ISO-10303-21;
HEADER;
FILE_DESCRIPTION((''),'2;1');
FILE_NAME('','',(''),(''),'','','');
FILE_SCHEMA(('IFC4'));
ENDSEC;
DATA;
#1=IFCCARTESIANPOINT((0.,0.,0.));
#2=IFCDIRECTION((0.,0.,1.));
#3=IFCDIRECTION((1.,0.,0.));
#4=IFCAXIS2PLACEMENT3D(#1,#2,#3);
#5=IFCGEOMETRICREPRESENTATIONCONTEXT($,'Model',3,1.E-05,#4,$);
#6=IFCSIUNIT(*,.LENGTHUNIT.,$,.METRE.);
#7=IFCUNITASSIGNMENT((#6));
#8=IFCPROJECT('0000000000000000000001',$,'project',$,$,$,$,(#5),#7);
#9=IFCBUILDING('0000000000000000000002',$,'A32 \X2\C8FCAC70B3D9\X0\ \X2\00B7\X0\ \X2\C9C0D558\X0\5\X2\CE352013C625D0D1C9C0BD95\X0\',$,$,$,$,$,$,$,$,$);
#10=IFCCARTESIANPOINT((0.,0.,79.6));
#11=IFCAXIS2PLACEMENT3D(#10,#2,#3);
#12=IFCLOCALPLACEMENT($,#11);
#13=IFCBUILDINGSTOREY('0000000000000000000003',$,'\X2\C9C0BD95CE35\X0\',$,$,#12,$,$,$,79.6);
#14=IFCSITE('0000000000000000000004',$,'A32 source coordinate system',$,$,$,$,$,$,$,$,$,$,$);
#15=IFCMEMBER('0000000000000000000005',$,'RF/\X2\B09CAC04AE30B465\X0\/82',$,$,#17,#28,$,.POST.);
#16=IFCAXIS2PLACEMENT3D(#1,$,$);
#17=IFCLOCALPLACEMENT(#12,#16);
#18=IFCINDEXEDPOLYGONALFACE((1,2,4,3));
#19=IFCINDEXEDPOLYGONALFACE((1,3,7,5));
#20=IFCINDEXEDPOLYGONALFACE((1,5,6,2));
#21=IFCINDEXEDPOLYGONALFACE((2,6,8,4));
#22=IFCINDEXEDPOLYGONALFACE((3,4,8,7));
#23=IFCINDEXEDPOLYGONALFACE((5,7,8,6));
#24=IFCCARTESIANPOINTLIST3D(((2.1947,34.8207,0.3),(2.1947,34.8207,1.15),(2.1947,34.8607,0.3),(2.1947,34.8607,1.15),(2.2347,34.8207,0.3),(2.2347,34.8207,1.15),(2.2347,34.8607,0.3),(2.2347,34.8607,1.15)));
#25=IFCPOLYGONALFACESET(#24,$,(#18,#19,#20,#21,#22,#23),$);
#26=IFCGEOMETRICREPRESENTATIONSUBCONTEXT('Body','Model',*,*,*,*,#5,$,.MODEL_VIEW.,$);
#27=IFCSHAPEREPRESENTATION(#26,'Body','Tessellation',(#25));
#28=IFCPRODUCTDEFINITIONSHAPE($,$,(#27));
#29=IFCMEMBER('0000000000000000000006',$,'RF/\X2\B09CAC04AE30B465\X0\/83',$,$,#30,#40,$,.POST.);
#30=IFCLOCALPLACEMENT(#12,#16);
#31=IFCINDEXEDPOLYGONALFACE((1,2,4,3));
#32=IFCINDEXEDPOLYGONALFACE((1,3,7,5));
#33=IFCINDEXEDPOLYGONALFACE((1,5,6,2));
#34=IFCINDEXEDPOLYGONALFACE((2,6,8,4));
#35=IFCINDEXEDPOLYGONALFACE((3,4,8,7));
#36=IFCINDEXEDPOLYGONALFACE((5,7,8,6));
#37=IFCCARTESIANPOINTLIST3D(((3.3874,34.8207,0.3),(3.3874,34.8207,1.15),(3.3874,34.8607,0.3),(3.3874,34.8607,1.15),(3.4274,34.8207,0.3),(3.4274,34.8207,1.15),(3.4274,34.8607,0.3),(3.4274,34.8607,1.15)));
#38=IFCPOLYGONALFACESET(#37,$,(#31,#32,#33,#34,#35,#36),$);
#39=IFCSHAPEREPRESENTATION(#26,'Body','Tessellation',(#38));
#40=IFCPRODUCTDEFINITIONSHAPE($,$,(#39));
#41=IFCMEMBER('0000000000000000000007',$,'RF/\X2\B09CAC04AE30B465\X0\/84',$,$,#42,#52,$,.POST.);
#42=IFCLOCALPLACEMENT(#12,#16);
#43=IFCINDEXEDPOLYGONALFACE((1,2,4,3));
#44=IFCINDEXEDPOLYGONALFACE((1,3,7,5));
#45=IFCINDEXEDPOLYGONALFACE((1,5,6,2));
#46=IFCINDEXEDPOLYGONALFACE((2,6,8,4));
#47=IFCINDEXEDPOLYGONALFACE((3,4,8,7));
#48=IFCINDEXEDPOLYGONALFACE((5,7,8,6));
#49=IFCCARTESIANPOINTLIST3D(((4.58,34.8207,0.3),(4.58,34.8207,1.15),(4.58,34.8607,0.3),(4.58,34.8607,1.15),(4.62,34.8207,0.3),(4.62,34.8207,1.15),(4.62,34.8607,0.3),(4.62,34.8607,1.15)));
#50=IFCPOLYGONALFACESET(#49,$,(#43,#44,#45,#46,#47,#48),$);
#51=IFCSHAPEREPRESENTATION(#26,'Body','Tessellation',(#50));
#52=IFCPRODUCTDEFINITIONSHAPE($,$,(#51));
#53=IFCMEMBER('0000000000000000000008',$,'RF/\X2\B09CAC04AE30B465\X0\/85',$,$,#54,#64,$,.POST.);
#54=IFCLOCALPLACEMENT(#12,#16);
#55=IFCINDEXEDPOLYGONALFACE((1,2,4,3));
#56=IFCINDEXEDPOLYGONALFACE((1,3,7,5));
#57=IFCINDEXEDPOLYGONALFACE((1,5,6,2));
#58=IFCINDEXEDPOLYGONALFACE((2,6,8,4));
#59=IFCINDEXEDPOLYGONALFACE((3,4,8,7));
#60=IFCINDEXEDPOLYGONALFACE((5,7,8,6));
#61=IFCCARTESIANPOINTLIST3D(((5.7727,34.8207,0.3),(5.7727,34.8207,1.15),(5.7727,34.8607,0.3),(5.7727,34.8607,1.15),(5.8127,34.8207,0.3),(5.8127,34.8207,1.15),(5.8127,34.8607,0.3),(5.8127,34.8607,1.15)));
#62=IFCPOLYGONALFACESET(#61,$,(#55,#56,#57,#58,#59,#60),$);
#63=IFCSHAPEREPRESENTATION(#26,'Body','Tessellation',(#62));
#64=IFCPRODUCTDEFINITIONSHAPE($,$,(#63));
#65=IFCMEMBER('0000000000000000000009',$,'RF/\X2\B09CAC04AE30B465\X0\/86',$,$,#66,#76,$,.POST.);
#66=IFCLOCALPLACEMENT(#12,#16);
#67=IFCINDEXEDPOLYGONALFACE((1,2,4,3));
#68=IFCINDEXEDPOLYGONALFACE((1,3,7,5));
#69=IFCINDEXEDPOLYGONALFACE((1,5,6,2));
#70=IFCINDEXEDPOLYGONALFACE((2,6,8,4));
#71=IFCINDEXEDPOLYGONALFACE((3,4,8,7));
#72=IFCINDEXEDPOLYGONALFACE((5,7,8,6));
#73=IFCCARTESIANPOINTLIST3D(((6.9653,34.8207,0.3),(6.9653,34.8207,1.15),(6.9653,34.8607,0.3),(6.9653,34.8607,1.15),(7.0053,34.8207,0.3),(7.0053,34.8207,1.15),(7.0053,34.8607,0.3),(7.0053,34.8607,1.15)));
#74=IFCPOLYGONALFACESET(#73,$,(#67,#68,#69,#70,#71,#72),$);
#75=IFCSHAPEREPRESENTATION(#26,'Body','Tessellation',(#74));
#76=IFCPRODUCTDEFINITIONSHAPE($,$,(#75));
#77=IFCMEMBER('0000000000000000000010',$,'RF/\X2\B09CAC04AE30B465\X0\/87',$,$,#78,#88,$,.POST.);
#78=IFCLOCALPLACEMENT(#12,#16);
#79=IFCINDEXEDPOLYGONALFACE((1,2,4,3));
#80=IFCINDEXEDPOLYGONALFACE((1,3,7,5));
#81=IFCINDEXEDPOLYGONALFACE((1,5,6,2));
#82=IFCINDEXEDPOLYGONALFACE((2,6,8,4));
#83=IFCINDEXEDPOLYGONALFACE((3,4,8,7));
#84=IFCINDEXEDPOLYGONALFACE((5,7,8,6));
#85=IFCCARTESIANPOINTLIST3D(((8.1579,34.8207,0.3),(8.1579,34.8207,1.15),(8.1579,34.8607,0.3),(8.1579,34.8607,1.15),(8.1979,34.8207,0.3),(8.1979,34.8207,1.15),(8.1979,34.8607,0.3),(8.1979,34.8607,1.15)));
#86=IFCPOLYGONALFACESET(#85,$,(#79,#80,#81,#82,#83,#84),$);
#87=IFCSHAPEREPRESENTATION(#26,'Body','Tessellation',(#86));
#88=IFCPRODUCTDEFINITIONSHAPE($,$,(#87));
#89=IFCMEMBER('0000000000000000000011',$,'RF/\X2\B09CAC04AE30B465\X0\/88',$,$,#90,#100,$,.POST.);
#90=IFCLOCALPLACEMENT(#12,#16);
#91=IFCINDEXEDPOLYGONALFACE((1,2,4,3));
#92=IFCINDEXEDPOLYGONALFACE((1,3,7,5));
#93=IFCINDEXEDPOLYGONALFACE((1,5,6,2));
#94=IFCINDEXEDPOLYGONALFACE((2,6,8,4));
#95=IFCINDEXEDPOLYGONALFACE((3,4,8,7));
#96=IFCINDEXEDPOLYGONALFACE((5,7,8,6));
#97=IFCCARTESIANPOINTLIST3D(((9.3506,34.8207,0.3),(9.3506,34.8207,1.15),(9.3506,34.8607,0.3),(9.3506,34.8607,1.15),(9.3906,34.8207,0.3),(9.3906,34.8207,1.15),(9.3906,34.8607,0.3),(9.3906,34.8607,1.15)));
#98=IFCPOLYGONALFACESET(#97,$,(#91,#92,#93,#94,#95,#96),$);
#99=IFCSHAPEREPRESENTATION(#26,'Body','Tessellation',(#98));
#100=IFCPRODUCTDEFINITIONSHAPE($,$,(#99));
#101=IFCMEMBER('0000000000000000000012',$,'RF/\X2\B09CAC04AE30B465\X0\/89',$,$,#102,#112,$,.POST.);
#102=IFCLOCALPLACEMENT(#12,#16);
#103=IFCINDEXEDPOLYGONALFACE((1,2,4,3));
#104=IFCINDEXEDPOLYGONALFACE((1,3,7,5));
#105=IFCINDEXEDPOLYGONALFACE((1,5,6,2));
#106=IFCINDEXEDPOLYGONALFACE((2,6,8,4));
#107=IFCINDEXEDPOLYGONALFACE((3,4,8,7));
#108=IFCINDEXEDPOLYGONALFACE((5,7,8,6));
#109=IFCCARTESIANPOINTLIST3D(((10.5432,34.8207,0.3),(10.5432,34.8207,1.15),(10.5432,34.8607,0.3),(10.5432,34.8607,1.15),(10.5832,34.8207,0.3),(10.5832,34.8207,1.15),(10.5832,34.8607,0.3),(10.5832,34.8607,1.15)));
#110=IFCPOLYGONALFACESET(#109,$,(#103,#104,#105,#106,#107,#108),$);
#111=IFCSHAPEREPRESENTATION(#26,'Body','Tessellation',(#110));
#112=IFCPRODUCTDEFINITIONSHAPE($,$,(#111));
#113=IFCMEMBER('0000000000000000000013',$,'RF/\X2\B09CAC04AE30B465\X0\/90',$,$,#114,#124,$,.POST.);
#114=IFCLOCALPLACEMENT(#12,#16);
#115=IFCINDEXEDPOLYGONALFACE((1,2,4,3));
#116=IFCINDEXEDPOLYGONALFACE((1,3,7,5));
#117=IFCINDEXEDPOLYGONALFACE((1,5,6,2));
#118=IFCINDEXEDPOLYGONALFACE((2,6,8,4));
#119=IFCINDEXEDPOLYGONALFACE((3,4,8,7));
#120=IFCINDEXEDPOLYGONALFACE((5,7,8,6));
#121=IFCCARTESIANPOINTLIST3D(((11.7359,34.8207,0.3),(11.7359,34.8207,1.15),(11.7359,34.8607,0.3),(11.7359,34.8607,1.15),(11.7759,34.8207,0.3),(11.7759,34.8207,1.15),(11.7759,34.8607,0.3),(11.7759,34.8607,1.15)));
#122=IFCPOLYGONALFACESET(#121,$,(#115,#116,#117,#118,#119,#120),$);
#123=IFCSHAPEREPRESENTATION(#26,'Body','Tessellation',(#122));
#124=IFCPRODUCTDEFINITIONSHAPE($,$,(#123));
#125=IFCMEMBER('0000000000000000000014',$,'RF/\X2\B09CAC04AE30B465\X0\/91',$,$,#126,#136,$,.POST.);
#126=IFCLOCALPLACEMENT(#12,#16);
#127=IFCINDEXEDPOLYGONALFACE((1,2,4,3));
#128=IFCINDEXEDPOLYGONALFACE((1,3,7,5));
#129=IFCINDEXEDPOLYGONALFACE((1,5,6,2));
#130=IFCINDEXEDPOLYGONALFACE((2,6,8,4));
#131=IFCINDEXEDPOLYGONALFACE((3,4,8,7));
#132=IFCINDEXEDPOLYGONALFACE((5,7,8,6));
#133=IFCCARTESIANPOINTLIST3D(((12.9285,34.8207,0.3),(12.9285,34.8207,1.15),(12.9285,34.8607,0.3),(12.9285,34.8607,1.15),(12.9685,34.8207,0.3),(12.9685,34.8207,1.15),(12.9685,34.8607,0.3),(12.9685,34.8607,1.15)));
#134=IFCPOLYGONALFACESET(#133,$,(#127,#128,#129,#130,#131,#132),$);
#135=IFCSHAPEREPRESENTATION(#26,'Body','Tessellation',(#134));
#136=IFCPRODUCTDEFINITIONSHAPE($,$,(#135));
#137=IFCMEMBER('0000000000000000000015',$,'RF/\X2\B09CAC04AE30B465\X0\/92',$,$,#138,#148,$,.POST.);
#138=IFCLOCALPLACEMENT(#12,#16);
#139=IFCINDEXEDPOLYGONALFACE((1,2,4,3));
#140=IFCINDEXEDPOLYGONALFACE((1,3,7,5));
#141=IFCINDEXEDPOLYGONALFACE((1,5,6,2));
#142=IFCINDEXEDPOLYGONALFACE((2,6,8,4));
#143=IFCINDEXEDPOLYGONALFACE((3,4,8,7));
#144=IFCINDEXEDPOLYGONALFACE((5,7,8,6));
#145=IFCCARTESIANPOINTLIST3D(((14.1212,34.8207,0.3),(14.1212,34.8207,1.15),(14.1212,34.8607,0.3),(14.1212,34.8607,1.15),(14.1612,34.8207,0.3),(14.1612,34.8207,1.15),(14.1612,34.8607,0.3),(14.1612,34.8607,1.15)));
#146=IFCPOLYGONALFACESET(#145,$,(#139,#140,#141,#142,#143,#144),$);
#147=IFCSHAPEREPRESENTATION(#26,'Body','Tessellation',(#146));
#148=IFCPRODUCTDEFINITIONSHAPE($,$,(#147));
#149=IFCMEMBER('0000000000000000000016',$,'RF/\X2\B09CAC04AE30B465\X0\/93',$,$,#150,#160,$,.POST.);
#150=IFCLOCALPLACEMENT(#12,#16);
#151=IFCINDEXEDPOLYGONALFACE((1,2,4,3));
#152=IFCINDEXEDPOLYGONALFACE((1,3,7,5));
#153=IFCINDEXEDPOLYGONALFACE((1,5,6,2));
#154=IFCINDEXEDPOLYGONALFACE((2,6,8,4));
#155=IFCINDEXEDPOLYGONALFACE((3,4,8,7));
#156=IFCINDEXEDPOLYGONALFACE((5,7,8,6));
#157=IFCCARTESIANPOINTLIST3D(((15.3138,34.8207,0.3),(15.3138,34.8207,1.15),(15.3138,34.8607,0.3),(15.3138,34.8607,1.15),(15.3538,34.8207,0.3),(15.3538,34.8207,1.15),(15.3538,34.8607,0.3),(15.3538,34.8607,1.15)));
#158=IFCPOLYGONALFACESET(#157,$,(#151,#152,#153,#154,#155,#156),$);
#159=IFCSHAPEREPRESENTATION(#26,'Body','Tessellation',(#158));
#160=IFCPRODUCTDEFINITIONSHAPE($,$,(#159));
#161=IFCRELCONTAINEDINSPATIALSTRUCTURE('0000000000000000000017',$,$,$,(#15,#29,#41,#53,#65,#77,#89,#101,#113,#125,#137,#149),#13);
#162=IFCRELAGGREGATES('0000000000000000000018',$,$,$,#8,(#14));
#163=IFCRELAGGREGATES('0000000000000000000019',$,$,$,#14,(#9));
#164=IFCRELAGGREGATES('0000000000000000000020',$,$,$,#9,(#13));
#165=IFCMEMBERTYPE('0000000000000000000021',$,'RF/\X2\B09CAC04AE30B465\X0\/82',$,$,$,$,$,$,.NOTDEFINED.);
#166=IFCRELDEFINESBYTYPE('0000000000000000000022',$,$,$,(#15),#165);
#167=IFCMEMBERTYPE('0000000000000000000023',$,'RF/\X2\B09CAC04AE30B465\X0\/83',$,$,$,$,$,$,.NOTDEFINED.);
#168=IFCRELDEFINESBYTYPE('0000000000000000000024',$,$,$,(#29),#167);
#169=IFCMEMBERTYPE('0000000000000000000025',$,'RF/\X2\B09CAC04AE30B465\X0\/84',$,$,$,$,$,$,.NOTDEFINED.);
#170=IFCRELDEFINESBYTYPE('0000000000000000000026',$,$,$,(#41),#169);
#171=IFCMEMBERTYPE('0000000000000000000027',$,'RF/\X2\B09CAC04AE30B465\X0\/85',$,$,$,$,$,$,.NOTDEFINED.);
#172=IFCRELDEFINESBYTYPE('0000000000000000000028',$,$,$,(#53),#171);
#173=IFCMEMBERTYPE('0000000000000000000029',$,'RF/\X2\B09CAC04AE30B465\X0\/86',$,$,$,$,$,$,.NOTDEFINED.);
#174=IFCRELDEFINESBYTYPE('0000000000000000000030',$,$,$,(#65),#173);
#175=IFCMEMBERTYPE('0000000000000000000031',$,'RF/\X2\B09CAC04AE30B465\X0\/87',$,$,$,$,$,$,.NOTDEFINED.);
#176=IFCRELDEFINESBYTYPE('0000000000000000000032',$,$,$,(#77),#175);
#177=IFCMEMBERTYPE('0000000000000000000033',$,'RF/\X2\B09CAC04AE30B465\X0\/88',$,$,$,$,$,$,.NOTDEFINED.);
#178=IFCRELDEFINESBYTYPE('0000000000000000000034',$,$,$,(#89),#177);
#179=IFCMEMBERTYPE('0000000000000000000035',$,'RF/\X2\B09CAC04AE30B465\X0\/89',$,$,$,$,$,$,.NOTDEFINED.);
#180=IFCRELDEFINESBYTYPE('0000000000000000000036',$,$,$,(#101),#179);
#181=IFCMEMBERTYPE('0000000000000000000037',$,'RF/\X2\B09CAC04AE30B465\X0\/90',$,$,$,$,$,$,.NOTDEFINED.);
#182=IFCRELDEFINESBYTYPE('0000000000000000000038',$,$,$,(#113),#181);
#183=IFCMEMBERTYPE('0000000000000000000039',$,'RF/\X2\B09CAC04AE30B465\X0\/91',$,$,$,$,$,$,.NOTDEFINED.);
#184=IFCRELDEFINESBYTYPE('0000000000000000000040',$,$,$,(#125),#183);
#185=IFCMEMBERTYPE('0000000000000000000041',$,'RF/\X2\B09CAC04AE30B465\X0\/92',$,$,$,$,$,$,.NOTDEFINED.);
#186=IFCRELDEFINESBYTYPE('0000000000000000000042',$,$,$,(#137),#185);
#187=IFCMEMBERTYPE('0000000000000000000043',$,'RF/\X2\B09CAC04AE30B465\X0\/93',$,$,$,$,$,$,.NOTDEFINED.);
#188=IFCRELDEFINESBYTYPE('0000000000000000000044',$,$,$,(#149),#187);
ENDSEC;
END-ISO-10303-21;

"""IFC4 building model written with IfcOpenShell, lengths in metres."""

from ifc_helpers import new_model, si_unit, frame, origin, origin_with_axes, place, context, subcontext, project, spatial, polyline, outline, extrude, source, transform, mapped, type_object, type_shapes, element, save


model = new_model("IFC4")

# Units and contexts
model_context = context("Model", 3, precision=1e-05, world=origin_with_axes())
body_context = subcontext(model_context, "Body", "Model", "MODEL_VIEW")
ifc_project = project(units=[si_unit("LENGTHUNIT", "METRE")], contexts=[model_context])

# Site, building, storey
site = spatial("IfcSite", under=ifc_project, Name="A32 source coordinate system")
building = spatial("IfcBuilding", under=site, Name="A32 주거동 · 지하5층–옥탑지붕")
storey_placement = place(None, frame((0.0, 0.0, 79.6), z_axis=(0.0, 0.0, 1.0), x_axis=(1.0, 0.0, 0.0)))
storey = spatial("IfcBuildingStorey", under=building, at=storey_placement, Name="지붕층", Elevation=79.6)

# Members
member_type_1 = type_object("IfcMemberType", Name="RF/난간기둥/82", PredefinedType="NOTDEFINED")
shared_shape_1 = source(origin(), body_context, "Body", "SweptSolid", [
    extrude(outline(polyline([(2.2347, 34.8207), (2.1947, 34.8207), (2.1947, 34.8607), (2.2347, 34.8607), (2.2347, 34.8207)])), frame((0.0, 0.0, 0.3)), (0.0, 0.0, 1.0), 0.85),
])
type_shapes(member_type_1, [shared_shape_1])
member_1_placement = place(storey_placement, origin_with_axes())
element("IfcMember", 1, at=member_1_placement, inside=storey, type_object=member_type_1, Name="RF/난간기둥/82", PredefinedType="POST", context=body_context, shape_type="MappedRepresentation", body=[
    mapped(shared_shape_1, transform((0.0, 0.0, 0.0), scale=1.0)),
])
member_type_2 = type_object("IfcMemberType", Name="RF/난간기둥/83", PredefinedType="NOTDEFINED")
shared_shape_2 = source(origin(), body_context, "Body", "SweptSolid", [
    extrude(outline(polyline([(3.4274, 34.8207), (3.3874, 34.8207), (3.3874, 34.8607), (3.4274, 34.8607), (3.4274, 34.8207)])), frame((0.0, 0.0, 0.3)), (0.0, 0.0, 1.0), 0.85),
])
type_shapes(member_type_2, [shared_shape_2])
member_2_placement = place(storey_placement, origin_with_axes())
element("IfcMember", 2, at=member_2_placement, inside=storey, type_object=member_type_2, Name="RF/난간기둥/83", PredefinedType="POST", context=body_context, shape_type="MappedRepresentation", body=[
    mapped(shared_shape_2, transform((0.0, 0.0, 0.0), scale=1.0)),
])
member_type_3 = type_object("IfcMemberType", Name="RF/난간기둥/84", PredefinedType="NOTDEFINED")
shared_shape_3 = source(origin(), body_context, "Body", "SweptSolid", [
    extrude(outline(polyline([(4.62, 34.8207), (4.58, 34.8207), (4.58, 34.8607), (4.62, 34.8607), (4.62, 34.8207)])), frame((0.0, 0.0, 0.3)), (0.0, 0.0, 1.0), 0.85),
])
type_shapes(member_type_3, [shared_shape_3])
member_3_placement = place(storey_placement, origin_with_axes())
element("IfcMember", 3, at=member_3_placement, inside=storey, type_object=member_type_3, Name="RF/난간기둥/84", PredefinedType="POST", context=body_context, shape_type="MappedRepresentation", body=[
    mapped(shared_shape_3, transform((0.0, 0.0, 0.0), scale=1.0)),
])
member_type_4 = type_object("IfcMemberType", Name="RF/난간기둥/85", PredefinedType="NOTDEFINED")
shared_shape_4 = source(origin(), body_context, "Body", "SweptSolid", [
    extrude(outline(polyline([(5.8127, 34.8207), (5.7727, 34.8207), (5.7727, 34.8607), (5.8127, 34.8607), (5.8127, 34.8207)])), frame((0.0, 0.0, 0.3)), (0.0, 0.0, 1.0), 0.85),
])
type_shapes(member_type_4, [shared_shape_4])
member_4_placement = place(storey_placement, origin_with_axes())
element("IfcMember", 4, at=member_4_placement, inside=storey, type_object=member_type_4, Name="RF/난간기둥/85", PredefinedType="POST", context=body_context, shape_type="MappedRepresentation", body=[
    mapped(shared_shape_4, transform((0.0, 0.0, 0.0), scale=1.0)),
])
member_type_5 = type_object("IfcMemberType", Name="RF/난간기둥/86", PredefinedType="NOTDEFINED")
shared_shape_5 = source(origin(), body_context, "Body", "SweptSolid", [
    extrude(outline(polyline([(7.0053, 34.8207), (6.9653, 34.8207), (6.9653, 34.8607), (7.0053, 34.8607), (7.0053, 34.8207)])), frame((0.0, 0.0, 0.3)), (0.0, 0.0, 1.0), 0.85),
])
type_shapes(member_type_5, [shared_shape_5])
member_5_placement = place(storey_placement, origin_with_axes())
element("IfcMember", 5, at=member_5_placement, inside=storey, type_object=member_type_5, Name="RF/난간기둥/86", PredefinedType="POST", context=body_context, shape_type="MappedRepresentation", body=[
    mapped(shared_shape_5, transform((0.0, 0.0, 0.0), scale=1.0)),
])
member_type_6 = type_object("IfcMemberType", Name="RF/난간기둥/87", PredefinedType="NOTDEFINED")
shared_shape_6 = source(origin(), body_context, "Body", "SweptSolid", [
    extrude(outline(polyline([(8.1979, 34.8207), (8.1579, 34.8207), (8.1579, 34.8607), (8.1979, 34.8607), (8.1979, 34.8207)])), frame((0.0, 0.0, 0.3)), (0.0, 0.0, 1.0), 0.85),
])
type_shapes(member_type_6, [shared_shape_6])
member_6_placement = place(storey_placement, origin_with_axes())
element("IfcMember", 6, at=member_6_placement, inside=storey, type_object=member_type_6, Name="RF/난간기둥/87", PredefinedType="POST", context=body_context, shape_type="MappedRepresentation", body=[
    mapped(shared_shape_6, transform((0.0, 0.0, 0.0), scale=1.0)),
])
member_type_7 = type_object("IfcMemberType", Name="RF/난간기둥/88", PredefinedType="NOTDEFINED")
shared_shape_7 = source(origin(), body_context, "Body", "SweptSolid", [
    extrude(outline(polyline([(9.3906, 34.8207), (9.3506, 34.8207), (9.3506, 34.8607), (9.3906, 34.8607), (9.3906, 34.8207)])), frame((0.0, 0.0, 0.3)), (0.0, 0.0, 1.0), 0.85),
])
type_shapes(member_type_7, [shared_shape_7])
member_7_placement = place(storey_placement, origin_with_axes())
element("IfcMember", 7, at=member_7_placement, inside=storey, type_object=member_type_7, Name="RF/난간기둥/88", PredefinedType="POST", context=body_context, shape_type="MappedRepresentation", body=[
    mapped(shared_shape_7, transform((0.0, 0.0, 0.0), scale=1.0)),
])
member_type_8 = type_object("IfcMemberType", Name="RF/난간기둥/89", PredefinedType="NOTDEFINED")
shared_shape_8 = source(origin(), body_context, "Body", "SweptSolid", [
    extrude(outline(polyline([(10.5832, 34.8207), (10.5432, 34.8207), (10.5432, 34.8607), (10.5832, 34.8607), (10.5832, 34.8207)])), frame((0.0, 0.0, 0.3)), (0.0, 0.0, 1.0), 0.85),
])
type_shapes(member_type_8, [shared_shape_8])
member_8_placement = place(storey_placement, origin_with_axes())
element("IfcMember", 8, at=member_8_placement, inside=storey, type_object=member_type_8, Name="RF/난간기둥/89", PredefinedType="POST", context=body_context, shape_type="MappedRepresentation", body=[
    mapped(shared_shape_8, transform((0.0, 0.0, 0.0), scale=1.0)),
])
member_type_9 = type_object("IfcMemberType", Name="RF/난간기둥/90", PredefinedType="NOTDEFINED")
shared_shape_9 = source(origin(), body_context, "Body", "SweptSolid", [
    extrude(outline(polyline([(11.7759, 34.8207), (11.7359, 34.8207), (11.7359, 34.8607), (11.7759, 34.8607), (11.7759, 34.8207)])), frame((0.0, 0.0, 0.3)), (0.0, 0.0, 1.0), 0.85),
])
type_shapes(member_type_9, [shared_shape_9])
member_9_placement = place(storey_placement, origin_with_axes())
element("IfcMember", 9, at=member_9_placement, inside=storey, type_object=member_type_9, Name="RF/난간기둥/90", PredefinedType="POST", context=body_context, shape_type="MappedRepresentation", body=[
    mapped(shared_shape_9, transform((0.0, 0.0, 0.0), scale=1.0)),
])
member_type_10 = type_object("IfcMemberType", Name="RF/난간기둥/91", PredefinedType="NOTDEFINED")
shared_shape_10 = source(origin(), body_context, "Body", "SweptSolid", [
    extrude(outline(polyline([(12.9685, 34.8207), (12.9285, 34.8207), (12.9285, 34.8607), (12.9685, 34.8607), (12.9685, 34.8207)])), frame((0.0, 0.0, 0.3)), (0.0, 0.0, 1.0), 0.85),
])
type_shapes(member_type_10, [shared_shape_10])
member_10_placement = place(storey_placement, origin_with_axes())
element("IfcMember", 10, at=member_10_placement, inside=storey, type_object=member_type_10, Name="RF/난간기둥/91", PredefinedType="POST", context=body_context, shape_type="MappedRepresentation", body=[
    mapped(shared_shape_10, transform((0.0, 0.0, 0.0), scale=1.0)),
])
member_type_11 = type_object("IfcMemberType", Name="RF/난간기둥/92", PredefinedType="NOTDEFINED")
shared_shape_11 = source(origin(), body_context, "Body", "SweptSolid", [
    extrude(outline(polyline([(14.1612, 34.8207), (14.1212, 34.8207), (14.1212, 34.8607), (14.1612, 34.8607), (14.1612, 34.8207)])), frame((0.0, 0.0, 0.3)), (0.0, 0.0, 1.0), 0.85),
])
type_shapes(member_type_11, [shared_shape_11])
member_11_placement = place(storey_placement, origin_with_axes())
element("IfcMember", 11, at=member_11_placement, inside=storey, type_object=member_type_11, Name="RF/난간기둥/92", PredefinedType="POST", context=body_context, shape_type="MappedRepresentation", body=[
    mapped(shared_shape_11, transform((0.0, 0.0, 0.0), scale=1.0)),
])
member_type_12 = type_object("IfcMemberType", Name="RF/난간기둥/93", PredefinedType="NOTDEFINED")
shared_shape_12 = source(origin(), body_context, "Body", "SweptSolid", [
    extrude(outline(polyline([(15.3538, 34.8207), (15.3138, 34.8207), (15.3138, 34.8607), (15.3538, 34.8607), (15.3538, 34.8207)])), frame((0.0, 0.0, 0.3)), (0.0, 0.0, 1.0), 0.85),
])
type_shapes(member_type_12, [shared_shape_12])
member_12_placement = place(storey_placement, origin_with_axes())
element("IfcMember", 12, at=member_12_placement, inside=storey, type_object=member_type_12, Name="RF/난간기둥/93", PredefinedType="POST", context=body_context, shape_type="MappedRepresentation", body=[
    mapped(shared_shape_12, transform((0.0, 0.0, 0.0), scale=1.0)),
])

save(model, "model.ifc")
